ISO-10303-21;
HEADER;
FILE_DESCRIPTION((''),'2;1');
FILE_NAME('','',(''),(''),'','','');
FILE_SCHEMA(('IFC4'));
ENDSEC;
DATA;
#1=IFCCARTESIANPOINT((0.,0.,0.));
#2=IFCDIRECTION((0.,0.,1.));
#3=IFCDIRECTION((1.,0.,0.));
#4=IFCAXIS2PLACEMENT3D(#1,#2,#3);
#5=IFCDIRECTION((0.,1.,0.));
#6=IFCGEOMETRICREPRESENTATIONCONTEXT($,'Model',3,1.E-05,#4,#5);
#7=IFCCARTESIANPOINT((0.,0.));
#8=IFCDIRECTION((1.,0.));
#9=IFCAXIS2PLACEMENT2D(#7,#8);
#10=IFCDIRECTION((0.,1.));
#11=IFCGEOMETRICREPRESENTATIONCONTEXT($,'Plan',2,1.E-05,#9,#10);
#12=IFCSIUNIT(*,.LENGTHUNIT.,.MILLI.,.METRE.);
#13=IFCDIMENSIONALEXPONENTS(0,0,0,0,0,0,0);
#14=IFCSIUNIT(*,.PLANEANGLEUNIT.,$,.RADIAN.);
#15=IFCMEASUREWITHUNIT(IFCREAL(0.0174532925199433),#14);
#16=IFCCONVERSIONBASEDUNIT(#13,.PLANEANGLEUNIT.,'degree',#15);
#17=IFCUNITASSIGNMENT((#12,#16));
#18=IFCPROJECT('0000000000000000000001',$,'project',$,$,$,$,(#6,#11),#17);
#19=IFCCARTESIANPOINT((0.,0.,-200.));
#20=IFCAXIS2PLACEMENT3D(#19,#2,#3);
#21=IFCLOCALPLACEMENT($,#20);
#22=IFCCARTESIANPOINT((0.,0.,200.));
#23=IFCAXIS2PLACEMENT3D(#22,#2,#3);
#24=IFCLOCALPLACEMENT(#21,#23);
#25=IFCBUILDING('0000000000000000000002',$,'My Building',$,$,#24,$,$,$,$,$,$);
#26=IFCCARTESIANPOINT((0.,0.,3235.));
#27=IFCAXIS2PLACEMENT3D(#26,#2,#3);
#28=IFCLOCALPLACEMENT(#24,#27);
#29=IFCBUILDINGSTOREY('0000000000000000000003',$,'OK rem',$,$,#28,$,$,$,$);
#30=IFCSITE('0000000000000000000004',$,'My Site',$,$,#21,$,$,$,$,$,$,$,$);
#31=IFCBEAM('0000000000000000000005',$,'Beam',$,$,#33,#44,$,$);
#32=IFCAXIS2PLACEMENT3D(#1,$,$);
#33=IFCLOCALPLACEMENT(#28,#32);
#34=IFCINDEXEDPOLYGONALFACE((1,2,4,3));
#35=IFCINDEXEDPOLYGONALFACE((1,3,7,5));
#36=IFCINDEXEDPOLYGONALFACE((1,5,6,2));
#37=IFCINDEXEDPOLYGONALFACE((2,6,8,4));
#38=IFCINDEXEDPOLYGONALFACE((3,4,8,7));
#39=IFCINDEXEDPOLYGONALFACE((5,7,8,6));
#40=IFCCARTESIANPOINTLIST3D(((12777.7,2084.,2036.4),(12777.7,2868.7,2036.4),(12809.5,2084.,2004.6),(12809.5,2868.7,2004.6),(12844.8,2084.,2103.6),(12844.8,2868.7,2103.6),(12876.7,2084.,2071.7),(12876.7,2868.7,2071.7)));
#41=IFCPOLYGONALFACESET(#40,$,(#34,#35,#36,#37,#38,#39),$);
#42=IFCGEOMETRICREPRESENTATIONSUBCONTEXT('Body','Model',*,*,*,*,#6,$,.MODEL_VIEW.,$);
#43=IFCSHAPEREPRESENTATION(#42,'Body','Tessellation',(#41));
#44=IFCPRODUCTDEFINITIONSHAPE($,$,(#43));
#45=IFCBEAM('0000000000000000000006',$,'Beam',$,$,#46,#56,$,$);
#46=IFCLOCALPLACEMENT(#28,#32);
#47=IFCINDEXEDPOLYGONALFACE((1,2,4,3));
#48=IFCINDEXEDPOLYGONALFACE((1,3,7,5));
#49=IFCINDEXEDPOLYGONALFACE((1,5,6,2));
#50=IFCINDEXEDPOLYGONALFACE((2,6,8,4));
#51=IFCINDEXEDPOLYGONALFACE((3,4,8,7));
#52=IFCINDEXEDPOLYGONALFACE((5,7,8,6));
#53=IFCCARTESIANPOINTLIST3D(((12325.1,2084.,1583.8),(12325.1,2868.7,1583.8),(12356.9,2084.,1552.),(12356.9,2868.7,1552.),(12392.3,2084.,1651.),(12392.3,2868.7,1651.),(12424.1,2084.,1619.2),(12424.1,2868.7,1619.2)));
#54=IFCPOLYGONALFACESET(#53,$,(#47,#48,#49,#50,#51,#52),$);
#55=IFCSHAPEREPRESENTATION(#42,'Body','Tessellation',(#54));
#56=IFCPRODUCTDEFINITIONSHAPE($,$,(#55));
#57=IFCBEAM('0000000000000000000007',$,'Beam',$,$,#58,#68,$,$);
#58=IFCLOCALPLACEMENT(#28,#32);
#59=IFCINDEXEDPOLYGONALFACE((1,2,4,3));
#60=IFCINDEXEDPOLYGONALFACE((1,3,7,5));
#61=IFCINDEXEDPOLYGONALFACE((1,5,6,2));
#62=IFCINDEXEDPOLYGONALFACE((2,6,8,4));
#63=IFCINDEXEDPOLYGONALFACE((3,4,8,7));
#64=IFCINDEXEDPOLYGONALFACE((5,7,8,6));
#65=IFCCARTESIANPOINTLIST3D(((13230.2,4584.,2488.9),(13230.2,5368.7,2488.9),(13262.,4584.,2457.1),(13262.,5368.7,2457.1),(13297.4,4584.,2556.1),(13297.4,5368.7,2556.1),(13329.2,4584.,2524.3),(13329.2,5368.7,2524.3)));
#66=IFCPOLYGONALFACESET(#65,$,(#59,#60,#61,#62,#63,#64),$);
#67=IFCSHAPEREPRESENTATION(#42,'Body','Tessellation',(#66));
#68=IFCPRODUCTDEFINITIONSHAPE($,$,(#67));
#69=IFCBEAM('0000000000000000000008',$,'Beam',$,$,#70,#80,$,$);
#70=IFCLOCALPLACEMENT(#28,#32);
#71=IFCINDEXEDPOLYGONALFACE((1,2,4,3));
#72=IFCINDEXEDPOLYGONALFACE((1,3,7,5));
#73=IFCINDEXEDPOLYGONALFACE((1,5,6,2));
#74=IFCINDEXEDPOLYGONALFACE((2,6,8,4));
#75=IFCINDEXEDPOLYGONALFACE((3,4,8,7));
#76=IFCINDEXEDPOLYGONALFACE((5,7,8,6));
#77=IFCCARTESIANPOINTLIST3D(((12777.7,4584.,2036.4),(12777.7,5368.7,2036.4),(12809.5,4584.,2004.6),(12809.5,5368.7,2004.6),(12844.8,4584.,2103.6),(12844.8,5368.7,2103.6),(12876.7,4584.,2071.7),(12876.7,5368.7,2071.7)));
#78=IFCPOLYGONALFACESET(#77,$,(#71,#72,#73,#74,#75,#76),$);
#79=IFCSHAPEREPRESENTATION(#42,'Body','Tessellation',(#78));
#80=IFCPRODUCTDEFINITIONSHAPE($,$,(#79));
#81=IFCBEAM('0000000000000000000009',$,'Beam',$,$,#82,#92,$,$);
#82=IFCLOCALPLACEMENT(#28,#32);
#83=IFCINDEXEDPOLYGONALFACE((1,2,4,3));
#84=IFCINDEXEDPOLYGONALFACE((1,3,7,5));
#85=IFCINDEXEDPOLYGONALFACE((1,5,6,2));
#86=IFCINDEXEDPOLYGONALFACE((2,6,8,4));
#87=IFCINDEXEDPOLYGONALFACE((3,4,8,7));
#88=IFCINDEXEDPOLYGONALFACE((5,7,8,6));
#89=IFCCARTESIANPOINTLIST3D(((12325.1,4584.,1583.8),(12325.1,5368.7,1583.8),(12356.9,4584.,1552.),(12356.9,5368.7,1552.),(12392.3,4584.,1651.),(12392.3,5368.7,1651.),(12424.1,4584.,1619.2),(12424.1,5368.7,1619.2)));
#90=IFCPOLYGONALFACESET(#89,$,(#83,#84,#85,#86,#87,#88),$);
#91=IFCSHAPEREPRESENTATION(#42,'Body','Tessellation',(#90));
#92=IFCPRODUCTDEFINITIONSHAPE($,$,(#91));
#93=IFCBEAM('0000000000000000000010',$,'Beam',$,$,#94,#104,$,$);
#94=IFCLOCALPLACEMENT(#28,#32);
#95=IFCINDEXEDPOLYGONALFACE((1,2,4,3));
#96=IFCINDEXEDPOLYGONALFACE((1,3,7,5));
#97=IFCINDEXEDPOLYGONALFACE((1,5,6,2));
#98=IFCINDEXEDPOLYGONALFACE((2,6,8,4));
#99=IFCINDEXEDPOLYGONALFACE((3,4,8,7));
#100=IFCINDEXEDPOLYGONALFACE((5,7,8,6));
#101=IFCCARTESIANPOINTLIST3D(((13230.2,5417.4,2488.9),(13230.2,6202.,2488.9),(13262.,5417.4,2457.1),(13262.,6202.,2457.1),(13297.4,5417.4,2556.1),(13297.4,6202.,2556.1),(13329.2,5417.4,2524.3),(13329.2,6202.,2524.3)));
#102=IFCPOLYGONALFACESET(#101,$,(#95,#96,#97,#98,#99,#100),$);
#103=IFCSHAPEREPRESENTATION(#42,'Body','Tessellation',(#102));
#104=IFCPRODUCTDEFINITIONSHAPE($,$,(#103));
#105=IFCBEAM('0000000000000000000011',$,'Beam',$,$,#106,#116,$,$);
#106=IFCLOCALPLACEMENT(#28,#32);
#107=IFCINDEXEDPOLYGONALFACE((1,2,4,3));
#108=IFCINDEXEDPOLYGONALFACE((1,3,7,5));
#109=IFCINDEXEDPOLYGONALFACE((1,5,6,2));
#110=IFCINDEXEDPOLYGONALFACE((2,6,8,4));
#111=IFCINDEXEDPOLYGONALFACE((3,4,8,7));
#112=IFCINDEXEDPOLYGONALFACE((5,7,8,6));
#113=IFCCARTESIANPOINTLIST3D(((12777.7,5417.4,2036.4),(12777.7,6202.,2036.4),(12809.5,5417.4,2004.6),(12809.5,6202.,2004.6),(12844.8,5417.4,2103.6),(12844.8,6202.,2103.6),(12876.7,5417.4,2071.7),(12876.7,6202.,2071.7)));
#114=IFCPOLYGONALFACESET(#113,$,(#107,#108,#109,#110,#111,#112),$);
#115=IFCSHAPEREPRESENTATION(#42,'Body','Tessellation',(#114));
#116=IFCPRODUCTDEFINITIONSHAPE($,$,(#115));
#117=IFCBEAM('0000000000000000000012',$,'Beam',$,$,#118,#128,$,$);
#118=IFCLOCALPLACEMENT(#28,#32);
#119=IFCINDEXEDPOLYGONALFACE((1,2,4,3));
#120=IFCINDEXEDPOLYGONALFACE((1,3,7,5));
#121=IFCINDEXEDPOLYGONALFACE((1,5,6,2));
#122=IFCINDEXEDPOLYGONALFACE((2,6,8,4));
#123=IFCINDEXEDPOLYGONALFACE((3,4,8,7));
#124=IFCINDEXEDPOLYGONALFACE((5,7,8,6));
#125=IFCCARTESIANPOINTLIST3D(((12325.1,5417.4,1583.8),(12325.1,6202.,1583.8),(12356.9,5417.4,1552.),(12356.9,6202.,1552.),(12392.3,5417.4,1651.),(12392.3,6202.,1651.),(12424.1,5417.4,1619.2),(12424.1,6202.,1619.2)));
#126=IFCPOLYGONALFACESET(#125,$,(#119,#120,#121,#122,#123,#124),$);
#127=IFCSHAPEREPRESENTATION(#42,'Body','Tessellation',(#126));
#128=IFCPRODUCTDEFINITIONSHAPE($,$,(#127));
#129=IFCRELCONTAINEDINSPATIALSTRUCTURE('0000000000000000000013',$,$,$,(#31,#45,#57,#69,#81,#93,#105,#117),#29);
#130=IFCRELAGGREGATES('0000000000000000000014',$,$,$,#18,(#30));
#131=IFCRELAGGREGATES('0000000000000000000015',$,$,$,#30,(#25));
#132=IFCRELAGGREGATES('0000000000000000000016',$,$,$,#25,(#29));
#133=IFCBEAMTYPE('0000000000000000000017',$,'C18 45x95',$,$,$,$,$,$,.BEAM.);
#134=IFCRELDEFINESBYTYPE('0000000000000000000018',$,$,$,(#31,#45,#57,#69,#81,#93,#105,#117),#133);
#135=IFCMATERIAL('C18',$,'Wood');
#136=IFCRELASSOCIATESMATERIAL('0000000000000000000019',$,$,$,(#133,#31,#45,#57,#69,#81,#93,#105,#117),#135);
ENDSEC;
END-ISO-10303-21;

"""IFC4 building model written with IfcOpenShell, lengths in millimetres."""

from ifc_helpers import new_model, entity, si_unit, converted_unit, direction, frame, origin_with_axes, origin_2d_with_axis, place, context, subcontext, project, spatial, rectangle, extrude, material, material_profile, profile_set, profile_usage, type_object, element, save


model = new_model("IFC4")

# Units and contexts
model_context = context("Model", 3, precision=1e-05, world=origin_with_axes(), true_north=direction((0.0, 1.0, 0.0)))
plan_context = context("Plan", 2, precision=1e-05, world=origin_2d_with_axis(), true_north=direction((0.0, 1.0)))
body_context = subcontext(model_context, "Body", "Model", "MODEL_VIEW")
ifc_project = project(units=[si_unit("LENGTHUNIT", "METRE", prefix="MILLI"), converted_unit("PLANEANGLEUNIT", "degree", entity("IfcReal", 0.0174532925199433), si_unit("PLANEANGLEUNIT", "RADIAN"), dimensions=[0, 0, 0, 0, 0, 0, 0])], contexts=[model_context, plan_context])

# Site, building, storey
site_placement = place(None, frame((0.0, 0.0, -200.0), z_axis=(0.0, 0.0, 1.0), x_axis=(1.0, 0.0, 0.0)))
site = spatial("IfcSite", under=ifc_project, at=site_placement, Name="My Site")
building_placement = place(site_placement, frame((0.0, 0.0, 200.0), z_axis=(0.0, 0.0, 1.0), x_axis=(1.0, 0.0, 0.0)))
building = spatial("IfcBuilding", under=site, at=building_placement, Name="My Building")
storey_placement = place(building_placement, frame((0.0, 0.0, 3235.0), z_axis=(0.0, 0.0, 1.0), x_axis=(1.0, 0.0, 0.0)))
storey = spatial("IfcBuildingStorey", under=building, at=storey_placement, Name="OK rem")

# Beams
ifc_material = material(Name="C18", Category="Wood")
ifc_material_profile = material_profile(ifc_material, rectangle(XDim=45.0, YDim=95.0))
ifc_profile_set = profile_set([ifc_material_profile], Name="woodStructural")
beam_type = type_object("IfcBeamType", Name="C18 45x95", PredefinedType="BEAM", material=ifc_profile_set)
ifc_profile_usage_1 = profile_usage(ifc_profile_set, cardinal=5)
beam_1_placement = place(storey_placement, frame((12827.2, 2084.0, 2054.1), z_axis=(0.0, 1.0, 0.0), x_axis=(-0.707107, 0.0, 0.707107)))
element("IfcBeam", 1, at=beam_1_placement, inside=storey, type_object=beam_type, material=ifc_profile_usage_1, Name="Beam", context=body_context, shape_type="SweptSolid", body=[
    extrude(rectangle(XDim=45.0, YDim=95.0), origin_with_axes(), (0.0, 0.0, 1.0), 784.6),
])
ifc_profile_usage_2 = profile_usage(ifc_profile_set, cardinal=5)
beam_2_placement = place(storey_placement, frame((12374.6, 2084.0, 1601.5), z_axis=(0.0, 1.0, 0.0), x_axis=(-0.707107, 0.0, 0.707107)))
element("IfcBeam", 2, at=beam_2_placement, inside=storey, type_object=beam_type, material=ifc_profile_usage_2, Name="Beam", context=body_context, shape_type="SweptSolid", body=[
    extrude(rectangle(XDim=45.0, YDim=95.0), origin_with_axes(), (0.0, 0.0, 1.0), 784.6),
])
ifc_profile_usage_3 = profile_usage(ifc_profile_set, cardinal=5)
beam_3_placement = place(storey_placement, frame((13279.7, 4584.0, 2506.6), z_axis=(0.0, 1.0, 0.0), x_axis=(-0.707107, 0.0, 0.707107)))
element("IfcBeam", 3, at=beam_3_placement, inside=storey, type_object=beam_type, material=ifc_profile_usage_3, Name="Beam", context=body_context, shape_type="SweptSolid", body=[
    extrude(rectangle(XDim=45.0, YDim=95.0), origin_with_axes(), (0.0, 0.0, 1.0), 784.6),
])
ifc_profile_usage_4 = profile_usage(ifc_profile_set, cardinal=5)
beam_4_placement = place(storey_placement, frame((12827.2, 4584.0, 2054.1), z_axis=(0.0, 1.0, 0.0), x_axis=(-0.707107, 0.0, 0.707107)))
element("IfcBeam", 4, at=beam_4_placement, inside=storey, type_object=beam_type, material=ifc_profile_usage_4, Name="Beam", context=body_context, shape_type="SweptSolid", body=[
    extrude(rectangle(XDim=45.0, YDim=95.0), origin_with_axes(), (0.0, 0.0, 1.0), 784.6),
])
ifc_profile_usage_5 = profile_usage(ifc_profile_set, cardinal=5)
beam_5_placement = place(storey_placement, frame((12374.6, 4584.0, 1601.5), z_axis=(0.0, 1.0, 0.0), x_axis=(-0.707107, 0.0, 0.707107)))
element("IfcBeam", 5, at=beam_5_placement, inside=storey, type_object=beam_type, material=ifc_profile_usage_5, Name="Beam", context=body_context, shape_type="SweptSolid", body=[
    extrude(rectangle(XDim=45.0, YDim=95.0), origin_with_axes(), (0.0, 0.0, 1.0), 784.6),
])
ifc_profile_usage_6 = profile_usage(ifc_profile_set, cardinal=5)
beam_6_placement = place(storey_placement, frame((13279.7, 5417.4, 2506.6), z_axis=(0.0, 1.0, 0.0), x_axis=(-0.707107, 0.0, 0.707107)))
element("IfcBeam", 6, at=beam_6_placement, inside=storey, type_object=beam_type, material=ifc_profile_usage_6, Name="Beam", context=body_context, shape_type="SweptSolid", body=[
    extrude(rectangle(XDim=45.0, YDim=95.0), origin_with_axes(), (0.0, 0.0, 1.0), 784.6),
])
ifc_profile_usage_7 = profile_usage(ifc_profile_set, cardinal=5)
beam_7_placement = place(storey_placement, frame((12827.2, 5417.4, 2054.1), z_axis=(0.0, 1.0, 0.0), x_axis=(-0.707107, 0.0, 0.707107)))
element("IfcBeam", 7, at=beam_7_placement, inside=storey, type_object=beam_type, material=ifc_profile_usage_7, Name="Beam", context=body_context, shape_type="SweptSolid", body=[
    extrude(rectangle(XDim=45.0, YDim=95.0), origin_with_axes(), (0.0, 0.0, 1.0), 784.6),
])
ifc_profile_usage_8 = profile_usage(ifc_profile_set, cardinal=5)
beam_8_placement = place(storey_placement, frame((12374.6, 5417.4, 1601.5), z_axis=(0.0, 1.0, 0.0), x_axis=(-0.707107, 0.0, 0.707107)))
element("IfcBeam", 8, at=beam_8_placement, inside=storey, type_object=beam_type, material=ifc_profile_usage_8, Name="Beam", context=body_context, shape_type="SweptSolid", body=[
    extrude(rectangle(XDim=45.0, YDim=95.0), origin_with_axes(), (0.0, 0.0, 1.0), 784.6),
])

save(model, "model.ifc")
